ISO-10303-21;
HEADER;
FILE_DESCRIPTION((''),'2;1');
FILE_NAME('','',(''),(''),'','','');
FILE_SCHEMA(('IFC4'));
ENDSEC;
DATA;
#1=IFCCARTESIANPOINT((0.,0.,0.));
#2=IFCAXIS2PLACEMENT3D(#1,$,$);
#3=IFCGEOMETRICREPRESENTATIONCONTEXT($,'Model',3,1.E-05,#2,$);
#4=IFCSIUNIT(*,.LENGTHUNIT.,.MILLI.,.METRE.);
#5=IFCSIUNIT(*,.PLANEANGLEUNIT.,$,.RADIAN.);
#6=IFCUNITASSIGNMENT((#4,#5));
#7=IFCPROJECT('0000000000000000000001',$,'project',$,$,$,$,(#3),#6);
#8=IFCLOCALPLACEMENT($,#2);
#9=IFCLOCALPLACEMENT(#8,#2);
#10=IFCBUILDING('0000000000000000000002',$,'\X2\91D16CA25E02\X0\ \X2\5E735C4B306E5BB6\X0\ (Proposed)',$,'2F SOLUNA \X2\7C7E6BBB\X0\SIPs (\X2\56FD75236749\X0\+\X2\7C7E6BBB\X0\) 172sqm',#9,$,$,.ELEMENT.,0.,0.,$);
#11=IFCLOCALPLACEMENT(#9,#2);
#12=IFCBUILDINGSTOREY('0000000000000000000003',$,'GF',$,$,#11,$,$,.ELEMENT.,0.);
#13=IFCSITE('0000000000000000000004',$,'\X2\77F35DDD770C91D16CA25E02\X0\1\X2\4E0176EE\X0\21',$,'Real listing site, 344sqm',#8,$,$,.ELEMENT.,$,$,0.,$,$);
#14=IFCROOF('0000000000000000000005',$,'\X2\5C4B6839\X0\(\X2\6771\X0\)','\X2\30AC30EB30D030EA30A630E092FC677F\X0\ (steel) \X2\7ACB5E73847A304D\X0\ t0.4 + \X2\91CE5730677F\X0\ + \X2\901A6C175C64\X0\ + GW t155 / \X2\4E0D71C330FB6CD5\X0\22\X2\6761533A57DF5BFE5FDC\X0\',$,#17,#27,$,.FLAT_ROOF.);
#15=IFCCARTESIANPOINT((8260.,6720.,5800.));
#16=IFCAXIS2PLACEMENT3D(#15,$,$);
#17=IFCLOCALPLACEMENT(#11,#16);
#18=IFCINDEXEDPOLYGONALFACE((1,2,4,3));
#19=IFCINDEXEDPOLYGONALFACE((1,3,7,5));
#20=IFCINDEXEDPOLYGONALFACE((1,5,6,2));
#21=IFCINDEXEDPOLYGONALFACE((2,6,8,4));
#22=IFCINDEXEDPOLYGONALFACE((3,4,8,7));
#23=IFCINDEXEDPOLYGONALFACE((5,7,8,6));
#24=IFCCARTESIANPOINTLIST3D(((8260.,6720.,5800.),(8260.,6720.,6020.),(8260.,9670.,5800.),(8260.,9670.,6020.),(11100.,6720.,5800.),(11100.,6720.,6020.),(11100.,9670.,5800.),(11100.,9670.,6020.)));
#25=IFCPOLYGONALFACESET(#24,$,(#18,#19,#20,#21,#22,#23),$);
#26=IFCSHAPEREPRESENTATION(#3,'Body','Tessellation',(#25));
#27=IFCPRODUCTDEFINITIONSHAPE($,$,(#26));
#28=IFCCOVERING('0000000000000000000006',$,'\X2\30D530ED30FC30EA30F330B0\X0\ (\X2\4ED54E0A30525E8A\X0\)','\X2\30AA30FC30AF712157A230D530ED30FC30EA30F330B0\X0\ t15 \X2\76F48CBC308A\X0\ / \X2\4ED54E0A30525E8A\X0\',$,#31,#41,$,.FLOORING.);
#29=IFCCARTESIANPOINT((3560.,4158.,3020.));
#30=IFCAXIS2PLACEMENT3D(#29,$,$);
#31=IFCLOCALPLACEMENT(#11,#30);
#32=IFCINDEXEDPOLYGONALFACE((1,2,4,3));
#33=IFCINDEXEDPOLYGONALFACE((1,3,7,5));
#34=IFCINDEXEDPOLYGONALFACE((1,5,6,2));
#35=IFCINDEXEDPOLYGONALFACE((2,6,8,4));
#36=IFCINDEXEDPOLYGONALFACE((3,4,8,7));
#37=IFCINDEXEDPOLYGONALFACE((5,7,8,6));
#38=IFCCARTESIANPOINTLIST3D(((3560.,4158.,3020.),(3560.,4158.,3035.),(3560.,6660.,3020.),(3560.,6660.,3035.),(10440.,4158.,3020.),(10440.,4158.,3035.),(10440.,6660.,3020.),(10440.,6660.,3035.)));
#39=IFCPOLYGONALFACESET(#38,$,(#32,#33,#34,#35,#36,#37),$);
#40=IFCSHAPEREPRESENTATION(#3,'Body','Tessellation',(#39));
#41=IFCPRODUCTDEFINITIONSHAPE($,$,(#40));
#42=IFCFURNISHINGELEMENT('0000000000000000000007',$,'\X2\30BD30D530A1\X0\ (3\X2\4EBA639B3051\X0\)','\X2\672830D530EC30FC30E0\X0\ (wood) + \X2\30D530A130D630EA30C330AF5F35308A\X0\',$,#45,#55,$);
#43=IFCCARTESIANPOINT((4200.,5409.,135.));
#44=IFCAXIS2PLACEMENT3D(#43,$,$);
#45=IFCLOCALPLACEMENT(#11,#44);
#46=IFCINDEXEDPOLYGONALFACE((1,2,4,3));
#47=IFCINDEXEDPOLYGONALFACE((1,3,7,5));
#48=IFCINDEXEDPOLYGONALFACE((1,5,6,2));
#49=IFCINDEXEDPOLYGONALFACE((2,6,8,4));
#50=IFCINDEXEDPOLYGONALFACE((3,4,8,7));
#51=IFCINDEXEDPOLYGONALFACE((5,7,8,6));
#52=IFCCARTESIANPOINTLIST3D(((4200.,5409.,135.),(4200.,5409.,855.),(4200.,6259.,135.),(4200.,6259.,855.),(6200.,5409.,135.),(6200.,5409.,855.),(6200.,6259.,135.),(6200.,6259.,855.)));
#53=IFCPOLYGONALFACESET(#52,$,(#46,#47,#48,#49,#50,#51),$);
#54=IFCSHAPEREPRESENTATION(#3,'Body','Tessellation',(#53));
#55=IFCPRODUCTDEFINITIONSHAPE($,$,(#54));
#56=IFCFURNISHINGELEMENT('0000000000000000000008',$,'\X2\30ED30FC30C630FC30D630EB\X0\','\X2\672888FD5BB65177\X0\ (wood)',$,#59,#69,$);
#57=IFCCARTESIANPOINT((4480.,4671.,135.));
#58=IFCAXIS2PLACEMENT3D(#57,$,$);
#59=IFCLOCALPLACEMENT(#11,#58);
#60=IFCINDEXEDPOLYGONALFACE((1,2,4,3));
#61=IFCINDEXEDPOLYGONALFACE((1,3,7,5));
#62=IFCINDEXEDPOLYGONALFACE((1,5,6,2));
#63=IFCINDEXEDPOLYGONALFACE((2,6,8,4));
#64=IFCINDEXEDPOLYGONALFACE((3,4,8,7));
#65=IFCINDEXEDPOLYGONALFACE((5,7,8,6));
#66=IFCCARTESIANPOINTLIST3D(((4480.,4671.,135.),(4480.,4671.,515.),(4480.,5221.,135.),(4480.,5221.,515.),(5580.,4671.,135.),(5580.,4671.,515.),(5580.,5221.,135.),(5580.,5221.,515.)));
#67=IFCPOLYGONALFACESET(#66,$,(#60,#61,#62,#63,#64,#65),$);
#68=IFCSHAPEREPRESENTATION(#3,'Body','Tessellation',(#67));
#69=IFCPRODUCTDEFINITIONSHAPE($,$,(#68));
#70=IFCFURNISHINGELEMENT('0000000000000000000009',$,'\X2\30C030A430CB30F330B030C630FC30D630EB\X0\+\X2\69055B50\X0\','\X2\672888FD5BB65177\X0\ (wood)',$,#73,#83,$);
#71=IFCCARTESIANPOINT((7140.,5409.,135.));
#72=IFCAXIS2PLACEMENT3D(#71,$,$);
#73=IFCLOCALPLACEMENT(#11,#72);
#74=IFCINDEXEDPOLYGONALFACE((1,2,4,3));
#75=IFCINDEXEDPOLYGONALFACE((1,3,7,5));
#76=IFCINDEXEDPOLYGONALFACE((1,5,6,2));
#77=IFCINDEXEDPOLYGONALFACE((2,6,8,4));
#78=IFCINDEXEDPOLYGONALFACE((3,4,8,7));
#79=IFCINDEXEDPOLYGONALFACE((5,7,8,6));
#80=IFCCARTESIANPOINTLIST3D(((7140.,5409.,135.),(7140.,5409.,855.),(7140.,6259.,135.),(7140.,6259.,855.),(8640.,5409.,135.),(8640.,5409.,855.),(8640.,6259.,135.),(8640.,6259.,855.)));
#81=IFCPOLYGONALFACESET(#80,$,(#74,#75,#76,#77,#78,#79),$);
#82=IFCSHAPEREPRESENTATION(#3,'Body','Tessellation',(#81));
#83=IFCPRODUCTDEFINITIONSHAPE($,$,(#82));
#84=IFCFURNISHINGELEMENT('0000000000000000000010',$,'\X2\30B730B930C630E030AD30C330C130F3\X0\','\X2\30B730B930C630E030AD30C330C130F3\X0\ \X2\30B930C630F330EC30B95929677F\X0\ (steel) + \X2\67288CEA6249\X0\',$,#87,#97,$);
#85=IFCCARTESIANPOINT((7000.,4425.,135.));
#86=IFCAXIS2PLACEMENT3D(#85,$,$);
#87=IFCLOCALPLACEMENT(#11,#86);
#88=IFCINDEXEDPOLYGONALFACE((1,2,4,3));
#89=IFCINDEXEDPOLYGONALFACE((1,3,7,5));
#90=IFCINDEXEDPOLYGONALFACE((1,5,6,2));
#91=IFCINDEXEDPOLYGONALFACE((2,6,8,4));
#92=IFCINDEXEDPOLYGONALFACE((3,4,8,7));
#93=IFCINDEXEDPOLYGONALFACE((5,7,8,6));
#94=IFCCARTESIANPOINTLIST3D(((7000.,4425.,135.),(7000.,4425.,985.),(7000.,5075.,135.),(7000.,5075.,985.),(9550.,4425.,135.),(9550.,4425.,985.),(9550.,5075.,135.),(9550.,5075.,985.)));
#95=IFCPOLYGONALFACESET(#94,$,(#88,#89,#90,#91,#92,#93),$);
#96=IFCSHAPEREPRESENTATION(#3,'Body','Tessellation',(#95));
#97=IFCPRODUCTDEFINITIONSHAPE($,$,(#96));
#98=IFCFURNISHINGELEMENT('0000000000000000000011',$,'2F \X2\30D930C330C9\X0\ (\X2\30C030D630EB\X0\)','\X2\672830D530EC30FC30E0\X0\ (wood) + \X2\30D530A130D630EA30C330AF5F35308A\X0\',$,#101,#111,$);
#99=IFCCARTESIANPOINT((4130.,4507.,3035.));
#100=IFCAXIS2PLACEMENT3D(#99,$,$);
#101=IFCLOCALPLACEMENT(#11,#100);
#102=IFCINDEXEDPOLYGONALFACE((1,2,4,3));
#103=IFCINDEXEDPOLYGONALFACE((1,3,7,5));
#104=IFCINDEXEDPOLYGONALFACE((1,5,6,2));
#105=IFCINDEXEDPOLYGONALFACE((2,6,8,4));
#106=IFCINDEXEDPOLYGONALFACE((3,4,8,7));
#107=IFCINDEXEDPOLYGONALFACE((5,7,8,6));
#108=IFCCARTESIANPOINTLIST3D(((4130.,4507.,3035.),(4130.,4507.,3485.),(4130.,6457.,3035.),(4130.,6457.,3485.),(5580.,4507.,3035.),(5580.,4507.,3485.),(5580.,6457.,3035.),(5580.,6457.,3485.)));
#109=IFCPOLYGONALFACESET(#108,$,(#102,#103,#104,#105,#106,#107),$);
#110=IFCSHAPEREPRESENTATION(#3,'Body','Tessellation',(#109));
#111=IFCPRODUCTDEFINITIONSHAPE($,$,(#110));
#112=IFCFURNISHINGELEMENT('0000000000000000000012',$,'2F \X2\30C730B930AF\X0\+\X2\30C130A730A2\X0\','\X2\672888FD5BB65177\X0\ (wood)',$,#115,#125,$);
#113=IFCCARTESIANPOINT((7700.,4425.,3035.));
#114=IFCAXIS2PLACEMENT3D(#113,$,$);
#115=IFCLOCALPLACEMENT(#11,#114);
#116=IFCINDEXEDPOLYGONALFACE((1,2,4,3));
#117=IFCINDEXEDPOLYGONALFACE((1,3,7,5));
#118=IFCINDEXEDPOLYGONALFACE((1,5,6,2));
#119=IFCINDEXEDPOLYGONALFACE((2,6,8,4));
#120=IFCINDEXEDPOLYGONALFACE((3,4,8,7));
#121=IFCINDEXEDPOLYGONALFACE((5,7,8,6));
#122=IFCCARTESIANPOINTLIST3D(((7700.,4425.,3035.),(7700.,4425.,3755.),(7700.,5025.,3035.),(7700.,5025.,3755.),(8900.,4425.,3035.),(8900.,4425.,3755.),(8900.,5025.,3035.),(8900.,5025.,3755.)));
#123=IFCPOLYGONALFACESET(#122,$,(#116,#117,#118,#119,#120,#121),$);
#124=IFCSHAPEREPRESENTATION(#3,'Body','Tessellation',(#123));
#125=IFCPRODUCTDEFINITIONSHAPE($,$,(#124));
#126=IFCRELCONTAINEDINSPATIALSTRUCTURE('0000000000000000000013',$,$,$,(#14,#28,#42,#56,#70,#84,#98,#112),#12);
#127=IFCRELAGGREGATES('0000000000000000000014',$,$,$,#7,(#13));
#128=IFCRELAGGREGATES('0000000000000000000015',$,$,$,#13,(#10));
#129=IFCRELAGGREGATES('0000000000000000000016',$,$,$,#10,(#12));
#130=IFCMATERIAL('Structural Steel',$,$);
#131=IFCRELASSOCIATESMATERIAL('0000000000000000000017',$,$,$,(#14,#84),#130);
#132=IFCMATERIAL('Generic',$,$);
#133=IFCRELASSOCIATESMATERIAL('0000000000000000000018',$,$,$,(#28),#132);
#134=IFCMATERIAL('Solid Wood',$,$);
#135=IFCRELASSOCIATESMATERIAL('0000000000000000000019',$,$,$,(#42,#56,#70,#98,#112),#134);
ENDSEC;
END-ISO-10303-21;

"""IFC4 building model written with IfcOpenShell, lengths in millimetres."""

from ifc_helpers import new_model, si_unit, frame, frame_2d, origin, place, context, project, spatial, rectangle, extrude, material, element, save


model = new_model("IFC4")

# Units and contexts
model_context = context("Model", 3, precision=1e-05, world=origin())
ifc_project = project(units=[si_unit("LENGTHUNIT", "METRE", prefix="MILLI"), si_unit("PLANEANGLEUNIT", "RADIAN")], contexts=[model_context])

# Site, building, storey
site_placement = place(None, origin())
site = spatial("IfcSite", under=ifc_project, at=site_placement, Name="石川県金沢市1丁目21", ObjectType="Real listing site, 344sqm", CompositionType="ELEMENT", RefElevation=0.0)
building_placement = place(site_placement, origin())
building = spatial("IfcBuilding", under=site, at=building_placement, Name="金沢市 平屋の家 (Proposed)", ObjectType="2F SOLUNA 籾殻SIPs (国産杉+籾殻) 172sqm", CompositionType="ELEMENT", ElevationOfRefHeight=0.0, ElevationOfTerrain=0.0)
storey_placement = place(building_placement, origin())
storey = spatial("IfcBuildingStorey", under=building, at=storey_placement, Name="GF", CompositionType="ELEMENT", Elevation=0.0)

# Shared definitions
ifc_material_1 = material(Name="Solid Wood")

# Shared definitions
ifc_material_2 = material(Name="Generic")

# Roof
ifc_material_3 = material(Name="Structural Steel")
roof_placement = place(storey_placement, frame((8260.0, 6720.0, 5800.0)))
element("IfcRoof", 1, at=roof_placement, inside=storey, material=ifc_material_3, Name="屋根(東)", Description="ガルバリウム鋼板 (steel) 立平葺き t0.4 + 野地板 + 通気層 + GW t155 / 不燃・法22条区域対応", PredefinedType="FLAT_ROOF", context=model_context, shape_type="SweptSolid", body=[
    extrude(rectangle(XDim=2840.0, YDim=2950.0, at=frame_2d((1420.0, 1475.0))), frame((8260.0, 6720.0, 5800.0)), (0.0, 0.0, 1.0), 220.0),
])

# Covering
covering_placement = place(storey_placement, frame((3560.0, 4158.0, 3020.0)))
element("IfcCovering", 2, at=covering_placement, inside=storey, material=ifc_material_2, Name="フローリング (仕上げ床)", Description="オーク無垢フローリング t15 直貼り / 仕上げ床", PredefinedType="FLOORING", context=model_context, shape_type="SweptSolid", body=[
    extrude(rectangle(XDim=6880.0, YDim=2502.0, at=frame_2d((3440.0, 1251.0))), frame((3560.0, 4158.0, 3020.0)), (0.0, 0.0, 1.0), 15.0),
])

# Furnishing elements
furnishing_1_placement = place(storey_placement, frame((4200.0, 5409.0, 135.0)))
element("IfcFurnishingElement", 3, at=furnishing_1_placement, inside=storey, material=ifc_material_1, Name="ソファ (3人掛け)", Description="木フレーム (wood) + ファブリック張り", context=model_context, shape_type="SweptSolid", body=[
    extrude(rectangle(XDim=2000.0, YDim=850.0, at=frame_2d((1000.0, 425.0))), frame((4200.0, 5409.0, 135.0)), (0.0, 0.0, 1.0), 720.0),
])
furnishing_2_placement = place(storey_placement, frame((4480.0, 4671.0, 135.0)))
element("IfcFurnishingElement", 4, at=furnishing_2_placement, inside=storey, material=ifc_material_1, Name="ローテーブル", Description="木製家具 (wood)", context=model_context, shape_type="SweptSolid", body=[
    extrude(rectangle(XDim=1100.0, YDim=550.0, at=frame_2d((550.0, 275.0))), frame((4480.0, 4671.0, 135.0)), (0.0, 0.0, 1.0), 380.0),
])
furnishing_3_placement = place(storey_placement, frame((7140.0, 5409.0, 135.0)))
element("IfcFurnishingElement", 5, at=furnishing_3_placement, inside=storey, material=ifc_material_1, Name="ダイニングテーブル+椅子", Description="木製家具 (wood)", context=model_context, shape_type="SweptSolid", body=[
    extrude(rectangle(XDim=1500.0, YDim=850.0, at=frame_2d((750.0, 425.0))), frame((7140.0, 5409.0, 135.0)), (0.0, 0.0, 1.0), 720.0),
])
furnishing_4_placement = place(storey_placement, frame((7000.0, 4425.0, 135.0)))
element("IfcFurnishingElement", 6, at=furnishing_4_placement, inside=storey, material=ifc_material_3, Name="システムキッチン", Description="システムキッチン ステンレス天板 (steel) + 木質扉", context=model_context, shape_type="SweptSolid", body=[
    extrude(rectangle(XDim=2550.0, YDim=650.0, at=frame_2d((1275.0, 325.0))), frame((7000.0, 4425.0, 135.0)), (0.0, 0.0, 1.0), 850.0),
])
furnishing_5_placement = place(storey_placement, frame((4130.0, 4507.0, 3035.0)))
element("IfcFurnishingElement", 7, at=furnishing_5_placement, inside=storey, material=ifc_material_1, Name="2F ベッド (ダブル)", Description="木フレーム (wood) + ファブリック張り", context=model_context, shape_type="SweptSolid", body=[
    extrude(rectangle(XDim=1450.0, YDim=1950.0, at=frame_2d((725.0, 975.0))), frame((4130.0, 4507.0, 3035.0)), (0.0, 0.0, 1.0), 450.0),
])
furnishing_6_placement = place(storey_placement, frame((7700.0, 4425.0, 3035.0)))
element("IfcFurnishingElement", 8, at=furnishing_6_placement, inside=storey, material=ifc_material_1, Name="2F デスク+チェア", Description="木製家具 (wood)", context=model_context, shape_type="SweptSolid", body=[
    extrude(rectangle(XDim=1200.0, YDim=600.0, at=frame_2d((600.0, 300.0))), frame((7700.0, 4425.0, 3035.0)), (0.0, 0.0, 1.0), 720.0),
])

save(model, "model.ifc")
